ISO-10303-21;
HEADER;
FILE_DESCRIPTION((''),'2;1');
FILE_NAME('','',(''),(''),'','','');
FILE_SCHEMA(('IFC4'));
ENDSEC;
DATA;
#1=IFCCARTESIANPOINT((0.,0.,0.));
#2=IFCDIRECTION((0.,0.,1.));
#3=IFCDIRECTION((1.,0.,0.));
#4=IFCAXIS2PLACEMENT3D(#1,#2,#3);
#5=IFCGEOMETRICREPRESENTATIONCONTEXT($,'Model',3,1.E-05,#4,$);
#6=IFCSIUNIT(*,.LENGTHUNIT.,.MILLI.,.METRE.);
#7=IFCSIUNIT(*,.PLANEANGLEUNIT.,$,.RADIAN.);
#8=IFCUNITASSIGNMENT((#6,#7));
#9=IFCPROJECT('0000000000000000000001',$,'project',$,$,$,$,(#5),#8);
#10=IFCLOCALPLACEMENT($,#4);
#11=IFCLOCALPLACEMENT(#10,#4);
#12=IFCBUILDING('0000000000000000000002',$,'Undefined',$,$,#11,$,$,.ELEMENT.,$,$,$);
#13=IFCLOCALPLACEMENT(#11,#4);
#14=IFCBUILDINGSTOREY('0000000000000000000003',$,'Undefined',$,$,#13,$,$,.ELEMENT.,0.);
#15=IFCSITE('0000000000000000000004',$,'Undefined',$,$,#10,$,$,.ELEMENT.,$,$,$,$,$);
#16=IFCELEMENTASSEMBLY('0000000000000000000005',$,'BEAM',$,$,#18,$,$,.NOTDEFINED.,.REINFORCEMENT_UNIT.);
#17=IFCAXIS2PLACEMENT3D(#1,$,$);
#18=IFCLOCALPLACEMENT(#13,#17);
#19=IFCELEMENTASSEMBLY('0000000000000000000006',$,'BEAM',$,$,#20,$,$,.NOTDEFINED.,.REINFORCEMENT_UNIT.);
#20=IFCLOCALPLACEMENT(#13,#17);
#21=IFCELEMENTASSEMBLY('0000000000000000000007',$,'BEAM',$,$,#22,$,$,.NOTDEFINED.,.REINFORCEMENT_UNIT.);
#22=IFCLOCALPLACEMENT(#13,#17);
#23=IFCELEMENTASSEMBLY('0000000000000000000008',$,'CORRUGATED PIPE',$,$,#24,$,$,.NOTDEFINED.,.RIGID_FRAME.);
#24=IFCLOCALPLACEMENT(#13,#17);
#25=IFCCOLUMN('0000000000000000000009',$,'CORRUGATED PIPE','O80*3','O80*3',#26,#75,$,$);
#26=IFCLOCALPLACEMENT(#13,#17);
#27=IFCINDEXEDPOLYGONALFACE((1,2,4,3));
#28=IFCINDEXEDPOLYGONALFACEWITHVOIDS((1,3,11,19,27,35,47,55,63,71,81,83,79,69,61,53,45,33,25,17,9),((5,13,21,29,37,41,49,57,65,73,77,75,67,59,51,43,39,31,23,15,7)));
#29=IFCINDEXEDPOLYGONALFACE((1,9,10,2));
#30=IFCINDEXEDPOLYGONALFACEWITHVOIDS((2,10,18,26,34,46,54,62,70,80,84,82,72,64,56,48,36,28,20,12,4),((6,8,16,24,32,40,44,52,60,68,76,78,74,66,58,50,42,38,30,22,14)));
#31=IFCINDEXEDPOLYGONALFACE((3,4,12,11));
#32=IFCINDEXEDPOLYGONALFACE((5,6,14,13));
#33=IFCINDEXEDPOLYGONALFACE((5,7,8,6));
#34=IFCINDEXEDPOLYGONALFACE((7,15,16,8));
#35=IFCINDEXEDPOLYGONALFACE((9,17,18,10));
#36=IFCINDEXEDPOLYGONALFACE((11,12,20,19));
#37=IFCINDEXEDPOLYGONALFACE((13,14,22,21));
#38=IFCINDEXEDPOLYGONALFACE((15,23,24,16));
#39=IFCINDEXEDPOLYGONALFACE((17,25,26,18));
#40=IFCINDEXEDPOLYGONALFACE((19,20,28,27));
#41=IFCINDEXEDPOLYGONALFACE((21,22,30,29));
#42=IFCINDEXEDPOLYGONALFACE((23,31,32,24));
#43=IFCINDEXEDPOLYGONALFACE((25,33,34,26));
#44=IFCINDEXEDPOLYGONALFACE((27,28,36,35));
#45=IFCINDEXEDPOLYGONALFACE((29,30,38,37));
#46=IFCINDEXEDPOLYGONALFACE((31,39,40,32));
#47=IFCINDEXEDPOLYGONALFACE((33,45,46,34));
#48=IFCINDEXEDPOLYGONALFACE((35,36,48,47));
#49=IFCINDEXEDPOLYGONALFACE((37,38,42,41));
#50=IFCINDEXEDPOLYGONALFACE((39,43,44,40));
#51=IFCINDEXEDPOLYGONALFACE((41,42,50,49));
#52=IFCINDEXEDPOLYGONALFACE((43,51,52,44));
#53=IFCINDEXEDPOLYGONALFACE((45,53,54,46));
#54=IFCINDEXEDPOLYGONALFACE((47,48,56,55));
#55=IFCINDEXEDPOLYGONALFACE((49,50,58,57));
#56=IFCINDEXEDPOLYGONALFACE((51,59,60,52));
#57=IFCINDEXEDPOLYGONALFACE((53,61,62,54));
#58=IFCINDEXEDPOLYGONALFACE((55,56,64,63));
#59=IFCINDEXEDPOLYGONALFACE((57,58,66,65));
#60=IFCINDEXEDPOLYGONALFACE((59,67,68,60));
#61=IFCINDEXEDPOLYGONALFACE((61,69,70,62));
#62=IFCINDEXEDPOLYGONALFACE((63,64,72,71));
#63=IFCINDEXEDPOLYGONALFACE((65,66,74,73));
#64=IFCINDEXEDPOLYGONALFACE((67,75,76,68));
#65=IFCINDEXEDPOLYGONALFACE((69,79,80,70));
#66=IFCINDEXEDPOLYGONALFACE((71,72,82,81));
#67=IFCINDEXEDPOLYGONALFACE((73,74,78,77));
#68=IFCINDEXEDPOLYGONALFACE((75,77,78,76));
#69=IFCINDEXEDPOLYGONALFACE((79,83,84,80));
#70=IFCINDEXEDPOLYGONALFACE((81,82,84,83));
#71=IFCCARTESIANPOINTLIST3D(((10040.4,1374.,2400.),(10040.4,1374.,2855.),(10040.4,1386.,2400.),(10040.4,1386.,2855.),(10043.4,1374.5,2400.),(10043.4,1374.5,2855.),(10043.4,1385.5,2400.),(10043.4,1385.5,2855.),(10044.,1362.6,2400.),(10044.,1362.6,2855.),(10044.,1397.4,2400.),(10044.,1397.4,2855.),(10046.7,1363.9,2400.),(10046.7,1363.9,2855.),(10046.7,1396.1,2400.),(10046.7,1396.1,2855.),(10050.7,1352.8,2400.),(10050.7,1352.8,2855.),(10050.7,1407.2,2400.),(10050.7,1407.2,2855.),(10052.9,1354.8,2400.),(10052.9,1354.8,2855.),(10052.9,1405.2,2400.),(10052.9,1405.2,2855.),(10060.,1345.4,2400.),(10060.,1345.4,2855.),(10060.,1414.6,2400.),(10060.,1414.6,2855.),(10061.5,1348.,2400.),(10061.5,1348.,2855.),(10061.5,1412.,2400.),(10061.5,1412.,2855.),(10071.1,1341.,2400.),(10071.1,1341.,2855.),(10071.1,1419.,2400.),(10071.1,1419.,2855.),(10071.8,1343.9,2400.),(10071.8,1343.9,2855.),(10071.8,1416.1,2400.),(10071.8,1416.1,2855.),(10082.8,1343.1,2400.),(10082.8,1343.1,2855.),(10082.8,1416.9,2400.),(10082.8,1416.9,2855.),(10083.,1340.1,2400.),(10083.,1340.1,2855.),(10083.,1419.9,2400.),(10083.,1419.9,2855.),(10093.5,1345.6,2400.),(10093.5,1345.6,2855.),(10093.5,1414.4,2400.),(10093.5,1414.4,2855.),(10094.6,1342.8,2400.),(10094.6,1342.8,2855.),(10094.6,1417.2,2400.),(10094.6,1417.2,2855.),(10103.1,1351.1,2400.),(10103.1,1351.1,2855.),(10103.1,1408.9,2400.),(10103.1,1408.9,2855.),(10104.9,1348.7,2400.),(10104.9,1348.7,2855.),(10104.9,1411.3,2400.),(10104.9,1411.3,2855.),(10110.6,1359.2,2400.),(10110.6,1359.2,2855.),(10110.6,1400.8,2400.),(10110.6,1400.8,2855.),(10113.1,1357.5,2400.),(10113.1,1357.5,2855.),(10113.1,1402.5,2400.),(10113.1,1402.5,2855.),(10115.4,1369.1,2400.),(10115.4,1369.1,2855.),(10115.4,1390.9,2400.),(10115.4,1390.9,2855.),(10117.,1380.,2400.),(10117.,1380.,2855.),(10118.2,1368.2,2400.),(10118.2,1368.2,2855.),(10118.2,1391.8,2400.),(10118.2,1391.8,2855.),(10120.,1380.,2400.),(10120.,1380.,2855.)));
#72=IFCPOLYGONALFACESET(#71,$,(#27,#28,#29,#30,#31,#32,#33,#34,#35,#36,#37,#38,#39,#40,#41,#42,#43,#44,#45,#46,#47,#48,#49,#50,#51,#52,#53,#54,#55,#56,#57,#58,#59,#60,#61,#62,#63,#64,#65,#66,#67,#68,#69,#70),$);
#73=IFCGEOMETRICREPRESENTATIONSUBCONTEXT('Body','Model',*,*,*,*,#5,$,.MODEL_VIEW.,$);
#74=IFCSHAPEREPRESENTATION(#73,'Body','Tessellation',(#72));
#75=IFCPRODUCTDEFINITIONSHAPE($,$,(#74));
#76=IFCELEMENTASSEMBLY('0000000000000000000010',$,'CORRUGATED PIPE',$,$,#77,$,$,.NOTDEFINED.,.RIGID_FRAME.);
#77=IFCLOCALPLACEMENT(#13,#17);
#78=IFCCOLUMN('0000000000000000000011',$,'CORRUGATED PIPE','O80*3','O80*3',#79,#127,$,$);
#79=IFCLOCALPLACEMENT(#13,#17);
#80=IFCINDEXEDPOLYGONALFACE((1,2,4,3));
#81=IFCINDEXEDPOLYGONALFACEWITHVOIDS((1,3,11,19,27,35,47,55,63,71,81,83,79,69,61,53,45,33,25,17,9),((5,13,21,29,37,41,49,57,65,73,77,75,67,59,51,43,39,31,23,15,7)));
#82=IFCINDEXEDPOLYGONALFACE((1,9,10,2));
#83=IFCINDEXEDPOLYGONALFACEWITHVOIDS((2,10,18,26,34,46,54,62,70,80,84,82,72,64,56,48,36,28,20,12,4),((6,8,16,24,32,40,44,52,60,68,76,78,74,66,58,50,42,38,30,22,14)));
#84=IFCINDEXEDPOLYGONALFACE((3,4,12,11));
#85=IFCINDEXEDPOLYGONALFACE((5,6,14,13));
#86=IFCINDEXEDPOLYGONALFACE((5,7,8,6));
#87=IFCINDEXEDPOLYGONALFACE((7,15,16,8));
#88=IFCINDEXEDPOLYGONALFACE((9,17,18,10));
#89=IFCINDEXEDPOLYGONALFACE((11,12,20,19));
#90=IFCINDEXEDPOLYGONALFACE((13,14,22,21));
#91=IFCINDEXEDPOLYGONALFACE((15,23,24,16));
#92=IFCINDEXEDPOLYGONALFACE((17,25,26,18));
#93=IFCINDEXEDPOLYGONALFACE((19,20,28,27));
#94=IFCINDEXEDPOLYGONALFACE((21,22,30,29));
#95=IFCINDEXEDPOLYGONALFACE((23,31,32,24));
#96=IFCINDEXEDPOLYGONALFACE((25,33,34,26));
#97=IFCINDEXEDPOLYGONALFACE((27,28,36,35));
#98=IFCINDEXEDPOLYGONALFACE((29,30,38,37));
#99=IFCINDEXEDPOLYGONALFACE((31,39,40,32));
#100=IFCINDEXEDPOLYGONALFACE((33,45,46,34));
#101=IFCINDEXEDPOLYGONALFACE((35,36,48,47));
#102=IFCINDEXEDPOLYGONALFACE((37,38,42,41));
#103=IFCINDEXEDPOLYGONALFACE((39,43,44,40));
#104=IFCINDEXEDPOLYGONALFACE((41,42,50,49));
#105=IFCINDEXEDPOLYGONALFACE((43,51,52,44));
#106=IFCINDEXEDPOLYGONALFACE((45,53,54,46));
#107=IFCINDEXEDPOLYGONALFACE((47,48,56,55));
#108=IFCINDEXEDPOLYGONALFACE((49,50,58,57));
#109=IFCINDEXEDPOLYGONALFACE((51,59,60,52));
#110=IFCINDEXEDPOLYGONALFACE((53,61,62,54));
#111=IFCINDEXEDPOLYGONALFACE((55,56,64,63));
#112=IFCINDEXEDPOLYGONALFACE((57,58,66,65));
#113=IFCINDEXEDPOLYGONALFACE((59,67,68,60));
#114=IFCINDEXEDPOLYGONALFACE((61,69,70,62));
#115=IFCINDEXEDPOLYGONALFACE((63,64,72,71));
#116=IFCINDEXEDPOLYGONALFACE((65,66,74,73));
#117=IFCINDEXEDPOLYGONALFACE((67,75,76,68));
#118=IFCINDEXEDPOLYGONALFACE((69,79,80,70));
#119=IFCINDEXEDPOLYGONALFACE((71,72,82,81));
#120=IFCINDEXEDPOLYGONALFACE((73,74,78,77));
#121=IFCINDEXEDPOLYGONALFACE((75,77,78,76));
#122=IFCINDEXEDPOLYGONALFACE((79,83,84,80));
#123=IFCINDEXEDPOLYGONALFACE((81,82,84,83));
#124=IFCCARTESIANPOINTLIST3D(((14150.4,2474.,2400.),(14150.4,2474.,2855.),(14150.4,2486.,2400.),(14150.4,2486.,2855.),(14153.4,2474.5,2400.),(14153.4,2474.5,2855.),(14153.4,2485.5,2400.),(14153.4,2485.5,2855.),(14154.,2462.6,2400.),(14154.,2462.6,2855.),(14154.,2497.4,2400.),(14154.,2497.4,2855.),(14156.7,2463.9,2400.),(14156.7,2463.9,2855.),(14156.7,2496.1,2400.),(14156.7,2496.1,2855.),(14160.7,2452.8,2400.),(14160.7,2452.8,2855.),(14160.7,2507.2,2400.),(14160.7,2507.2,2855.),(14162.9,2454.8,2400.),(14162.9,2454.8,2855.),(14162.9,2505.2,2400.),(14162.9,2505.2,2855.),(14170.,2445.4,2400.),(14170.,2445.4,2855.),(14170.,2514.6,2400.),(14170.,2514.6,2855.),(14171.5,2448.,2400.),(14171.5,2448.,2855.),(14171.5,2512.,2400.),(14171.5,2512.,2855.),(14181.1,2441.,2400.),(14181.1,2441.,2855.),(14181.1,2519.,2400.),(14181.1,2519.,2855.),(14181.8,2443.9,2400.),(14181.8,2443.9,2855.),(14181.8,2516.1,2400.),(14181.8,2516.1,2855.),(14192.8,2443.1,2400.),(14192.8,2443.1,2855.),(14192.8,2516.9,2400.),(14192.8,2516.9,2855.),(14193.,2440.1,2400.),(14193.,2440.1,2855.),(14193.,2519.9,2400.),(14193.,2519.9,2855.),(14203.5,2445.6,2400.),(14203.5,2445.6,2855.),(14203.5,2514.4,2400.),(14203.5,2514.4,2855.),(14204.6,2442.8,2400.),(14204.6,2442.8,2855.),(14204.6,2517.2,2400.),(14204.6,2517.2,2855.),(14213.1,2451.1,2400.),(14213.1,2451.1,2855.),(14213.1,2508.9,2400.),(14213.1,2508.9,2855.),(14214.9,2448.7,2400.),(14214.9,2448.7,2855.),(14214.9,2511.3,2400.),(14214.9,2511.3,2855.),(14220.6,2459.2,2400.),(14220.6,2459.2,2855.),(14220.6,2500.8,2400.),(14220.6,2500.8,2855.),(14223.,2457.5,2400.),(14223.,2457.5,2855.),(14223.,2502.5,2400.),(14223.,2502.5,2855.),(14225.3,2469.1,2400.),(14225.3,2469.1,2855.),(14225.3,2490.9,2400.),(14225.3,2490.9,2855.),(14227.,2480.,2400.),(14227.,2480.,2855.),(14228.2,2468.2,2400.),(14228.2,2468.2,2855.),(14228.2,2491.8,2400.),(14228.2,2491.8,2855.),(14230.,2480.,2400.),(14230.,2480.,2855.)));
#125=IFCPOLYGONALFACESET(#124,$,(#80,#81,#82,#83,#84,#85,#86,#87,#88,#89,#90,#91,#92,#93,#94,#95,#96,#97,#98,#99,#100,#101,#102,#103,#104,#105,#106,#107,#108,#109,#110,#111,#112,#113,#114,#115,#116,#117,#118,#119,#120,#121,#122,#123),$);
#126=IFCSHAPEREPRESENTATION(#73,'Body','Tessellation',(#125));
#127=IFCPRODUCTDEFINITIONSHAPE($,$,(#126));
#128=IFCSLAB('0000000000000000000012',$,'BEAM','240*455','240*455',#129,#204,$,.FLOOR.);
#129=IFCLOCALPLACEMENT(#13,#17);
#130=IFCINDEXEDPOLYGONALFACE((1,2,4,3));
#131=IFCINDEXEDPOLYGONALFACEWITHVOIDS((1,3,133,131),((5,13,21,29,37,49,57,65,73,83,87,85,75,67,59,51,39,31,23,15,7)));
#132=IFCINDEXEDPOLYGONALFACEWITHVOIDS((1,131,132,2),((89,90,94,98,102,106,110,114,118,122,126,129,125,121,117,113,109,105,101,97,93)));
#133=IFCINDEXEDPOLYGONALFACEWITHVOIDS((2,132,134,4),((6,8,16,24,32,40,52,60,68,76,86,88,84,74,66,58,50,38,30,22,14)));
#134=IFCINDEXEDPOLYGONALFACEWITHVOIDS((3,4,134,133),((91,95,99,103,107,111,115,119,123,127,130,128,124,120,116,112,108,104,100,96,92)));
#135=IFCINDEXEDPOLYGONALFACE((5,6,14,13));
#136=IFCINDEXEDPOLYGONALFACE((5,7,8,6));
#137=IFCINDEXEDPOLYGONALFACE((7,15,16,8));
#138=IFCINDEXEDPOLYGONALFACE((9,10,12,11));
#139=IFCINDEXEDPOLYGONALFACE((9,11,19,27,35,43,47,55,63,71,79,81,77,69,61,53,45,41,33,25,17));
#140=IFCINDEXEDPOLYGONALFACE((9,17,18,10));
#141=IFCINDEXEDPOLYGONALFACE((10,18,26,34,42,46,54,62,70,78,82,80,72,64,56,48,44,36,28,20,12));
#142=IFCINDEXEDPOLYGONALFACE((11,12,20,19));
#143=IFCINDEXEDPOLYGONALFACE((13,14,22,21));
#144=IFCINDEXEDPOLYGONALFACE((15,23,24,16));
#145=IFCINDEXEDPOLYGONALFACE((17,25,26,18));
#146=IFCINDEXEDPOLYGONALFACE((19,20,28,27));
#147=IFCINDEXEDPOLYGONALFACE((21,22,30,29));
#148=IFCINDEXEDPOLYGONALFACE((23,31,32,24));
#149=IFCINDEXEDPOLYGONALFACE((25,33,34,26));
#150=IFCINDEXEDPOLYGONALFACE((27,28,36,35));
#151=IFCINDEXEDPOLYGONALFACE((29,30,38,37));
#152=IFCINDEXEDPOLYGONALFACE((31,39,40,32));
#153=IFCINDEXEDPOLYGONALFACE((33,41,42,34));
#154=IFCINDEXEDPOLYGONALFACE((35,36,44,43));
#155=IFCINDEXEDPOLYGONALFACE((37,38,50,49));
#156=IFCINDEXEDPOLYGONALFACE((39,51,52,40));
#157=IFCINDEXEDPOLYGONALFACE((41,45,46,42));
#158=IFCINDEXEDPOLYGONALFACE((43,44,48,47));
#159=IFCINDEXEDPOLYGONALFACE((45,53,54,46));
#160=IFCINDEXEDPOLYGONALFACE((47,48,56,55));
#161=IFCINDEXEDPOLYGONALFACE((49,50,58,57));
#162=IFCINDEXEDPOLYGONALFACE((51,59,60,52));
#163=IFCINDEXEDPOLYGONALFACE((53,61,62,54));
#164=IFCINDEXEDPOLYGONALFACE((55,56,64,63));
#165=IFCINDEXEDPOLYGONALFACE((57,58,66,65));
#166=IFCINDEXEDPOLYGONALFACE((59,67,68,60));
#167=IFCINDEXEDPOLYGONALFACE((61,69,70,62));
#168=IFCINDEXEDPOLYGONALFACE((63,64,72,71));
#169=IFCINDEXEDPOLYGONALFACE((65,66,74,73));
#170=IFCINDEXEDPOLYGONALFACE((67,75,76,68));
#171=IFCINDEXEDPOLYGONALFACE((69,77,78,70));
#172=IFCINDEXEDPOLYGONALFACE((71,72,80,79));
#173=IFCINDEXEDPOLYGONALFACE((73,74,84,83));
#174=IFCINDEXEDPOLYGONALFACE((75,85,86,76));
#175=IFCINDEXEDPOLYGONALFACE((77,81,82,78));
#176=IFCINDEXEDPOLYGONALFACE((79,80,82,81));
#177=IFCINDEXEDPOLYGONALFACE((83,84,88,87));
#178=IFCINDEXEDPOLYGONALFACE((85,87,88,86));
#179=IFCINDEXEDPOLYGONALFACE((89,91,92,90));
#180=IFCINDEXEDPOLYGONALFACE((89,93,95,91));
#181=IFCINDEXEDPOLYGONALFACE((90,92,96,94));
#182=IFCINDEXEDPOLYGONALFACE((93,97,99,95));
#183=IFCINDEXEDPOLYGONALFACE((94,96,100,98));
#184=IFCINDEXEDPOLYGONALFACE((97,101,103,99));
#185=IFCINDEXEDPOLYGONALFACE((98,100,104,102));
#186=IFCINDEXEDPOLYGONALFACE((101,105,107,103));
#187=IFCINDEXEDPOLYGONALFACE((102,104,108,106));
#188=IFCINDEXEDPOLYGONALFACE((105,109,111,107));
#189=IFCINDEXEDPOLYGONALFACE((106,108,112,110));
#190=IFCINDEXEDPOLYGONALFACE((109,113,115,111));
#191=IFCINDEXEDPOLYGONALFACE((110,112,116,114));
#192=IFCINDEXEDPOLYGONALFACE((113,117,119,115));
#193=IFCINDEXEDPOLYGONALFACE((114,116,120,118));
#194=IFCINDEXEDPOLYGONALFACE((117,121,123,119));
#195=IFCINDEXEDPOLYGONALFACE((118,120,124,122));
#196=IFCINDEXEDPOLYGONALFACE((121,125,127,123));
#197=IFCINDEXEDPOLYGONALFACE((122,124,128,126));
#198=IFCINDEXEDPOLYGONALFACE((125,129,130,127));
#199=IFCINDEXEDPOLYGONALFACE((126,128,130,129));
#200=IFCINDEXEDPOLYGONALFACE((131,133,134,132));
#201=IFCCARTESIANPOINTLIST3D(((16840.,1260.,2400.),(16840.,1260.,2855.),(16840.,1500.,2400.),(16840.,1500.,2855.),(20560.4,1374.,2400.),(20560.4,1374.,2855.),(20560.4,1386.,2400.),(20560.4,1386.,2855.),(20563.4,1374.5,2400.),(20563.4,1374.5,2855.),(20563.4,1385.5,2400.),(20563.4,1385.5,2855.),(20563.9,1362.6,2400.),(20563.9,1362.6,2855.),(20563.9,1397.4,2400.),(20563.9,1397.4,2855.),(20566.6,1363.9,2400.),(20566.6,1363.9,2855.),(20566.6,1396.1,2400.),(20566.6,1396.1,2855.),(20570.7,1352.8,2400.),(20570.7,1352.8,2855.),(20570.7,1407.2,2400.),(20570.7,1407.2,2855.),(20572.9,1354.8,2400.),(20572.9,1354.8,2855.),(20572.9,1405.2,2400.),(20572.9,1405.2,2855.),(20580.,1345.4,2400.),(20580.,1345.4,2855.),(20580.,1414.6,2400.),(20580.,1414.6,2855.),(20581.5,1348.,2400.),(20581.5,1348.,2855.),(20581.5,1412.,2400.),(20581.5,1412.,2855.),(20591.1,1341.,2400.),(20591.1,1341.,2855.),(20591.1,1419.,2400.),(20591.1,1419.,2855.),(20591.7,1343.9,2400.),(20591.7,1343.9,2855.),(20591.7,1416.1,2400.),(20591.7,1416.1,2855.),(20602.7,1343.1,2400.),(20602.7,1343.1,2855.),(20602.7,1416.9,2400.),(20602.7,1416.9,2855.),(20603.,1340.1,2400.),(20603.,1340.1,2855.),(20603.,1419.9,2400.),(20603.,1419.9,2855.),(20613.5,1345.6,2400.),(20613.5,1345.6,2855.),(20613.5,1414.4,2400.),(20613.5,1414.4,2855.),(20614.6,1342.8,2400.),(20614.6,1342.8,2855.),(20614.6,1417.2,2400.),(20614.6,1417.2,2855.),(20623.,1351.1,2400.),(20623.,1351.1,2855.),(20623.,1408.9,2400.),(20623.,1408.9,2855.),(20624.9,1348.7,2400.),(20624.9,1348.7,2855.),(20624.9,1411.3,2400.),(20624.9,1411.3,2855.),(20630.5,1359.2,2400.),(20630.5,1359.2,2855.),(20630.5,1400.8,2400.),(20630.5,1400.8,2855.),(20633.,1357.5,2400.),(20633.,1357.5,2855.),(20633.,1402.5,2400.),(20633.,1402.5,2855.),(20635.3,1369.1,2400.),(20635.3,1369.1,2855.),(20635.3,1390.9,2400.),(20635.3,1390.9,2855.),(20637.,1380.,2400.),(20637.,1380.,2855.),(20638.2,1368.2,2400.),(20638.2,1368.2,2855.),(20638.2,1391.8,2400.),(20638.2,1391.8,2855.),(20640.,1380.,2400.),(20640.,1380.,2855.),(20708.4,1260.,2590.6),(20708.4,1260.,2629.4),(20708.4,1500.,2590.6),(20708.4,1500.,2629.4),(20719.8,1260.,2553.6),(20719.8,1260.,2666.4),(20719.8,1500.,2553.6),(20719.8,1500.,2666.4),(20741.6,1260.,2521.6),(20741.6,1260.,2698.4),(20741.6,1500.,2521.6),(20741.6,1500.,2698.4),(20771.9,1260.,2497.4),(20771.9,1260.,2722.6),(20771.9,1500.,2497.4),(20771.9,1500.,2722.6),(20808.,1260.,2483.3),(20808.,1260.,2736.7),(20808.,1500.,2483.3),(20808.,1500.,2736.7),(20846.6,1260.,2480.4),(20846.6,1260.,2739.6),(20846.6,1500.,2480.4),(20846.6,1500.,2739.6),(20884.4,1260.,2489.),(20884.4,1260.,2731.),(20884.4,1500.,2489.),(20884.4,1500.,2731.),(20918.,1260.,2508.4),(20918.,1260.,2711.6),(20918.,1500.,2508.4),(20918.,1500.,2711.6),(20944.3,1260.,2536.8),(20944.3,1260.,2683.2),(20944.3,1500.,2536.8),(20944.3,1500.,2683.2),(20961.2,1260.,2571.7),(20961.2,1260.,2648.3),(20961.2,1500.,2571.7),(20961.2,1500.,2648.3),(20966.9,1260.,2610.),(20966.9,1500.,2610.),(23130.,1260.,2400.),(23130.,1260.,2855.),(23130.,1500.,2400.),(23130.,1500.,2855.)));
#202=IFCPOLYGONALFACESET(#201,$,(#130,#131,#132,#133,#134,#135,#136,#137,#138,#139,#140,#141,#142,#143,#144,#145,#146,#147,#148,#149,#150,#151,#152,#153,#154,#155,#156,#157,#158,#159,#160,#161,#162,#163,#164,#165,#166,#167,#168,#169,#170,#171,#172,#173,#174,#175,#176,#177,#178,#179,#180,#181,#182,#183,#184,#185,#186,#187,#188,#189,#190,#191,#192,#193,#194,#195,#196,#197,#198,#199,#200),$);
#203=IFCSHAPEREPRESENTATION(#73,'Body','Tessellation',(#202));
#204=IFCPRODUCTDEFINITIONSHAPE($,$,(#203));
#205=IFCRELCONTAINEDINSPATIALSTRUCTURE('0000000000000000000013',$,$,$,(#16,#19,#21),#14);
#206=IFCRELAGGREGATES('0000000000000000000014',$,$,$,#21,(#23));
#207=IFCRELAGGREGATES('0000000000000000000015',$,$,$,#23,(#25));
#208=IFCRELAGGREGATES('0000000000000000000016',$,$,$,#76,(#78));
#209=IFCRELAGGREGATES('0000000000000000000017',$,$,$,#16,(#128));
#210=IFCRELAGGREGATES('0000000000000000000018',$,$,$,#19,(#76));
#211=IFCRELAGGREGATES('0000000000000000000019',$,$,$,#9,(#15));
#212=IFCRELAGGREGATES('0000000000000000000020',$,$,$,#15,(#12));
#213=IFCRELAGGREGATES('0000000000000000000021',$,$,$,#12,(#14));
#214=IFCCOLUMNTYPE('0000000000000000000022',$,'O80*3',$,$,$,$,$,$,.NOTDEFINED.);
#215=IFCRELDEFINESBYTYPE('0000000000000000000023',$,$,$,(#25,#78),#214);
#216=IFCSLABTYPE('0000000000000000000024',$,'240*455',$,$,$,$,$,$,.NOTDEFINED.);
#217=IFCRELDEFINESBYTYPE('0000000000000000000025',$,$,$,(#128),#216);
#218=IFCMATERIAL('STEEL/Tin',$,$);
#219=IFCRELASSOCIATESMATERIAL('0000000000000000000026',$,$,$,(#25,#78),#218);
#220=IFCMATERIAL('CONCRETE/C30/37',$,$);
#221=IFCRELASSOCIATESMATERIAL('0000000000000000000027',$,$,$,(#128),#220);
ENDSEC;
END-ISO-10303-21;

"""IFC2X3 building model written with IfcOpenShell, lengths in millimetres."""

from ifc_helpers import new_model, si_unit, frame, origin_with_axes, origin_2d_with_axis, place, context, subcontext, project, spatial, polyline, circle, hollow_circle, outline, extrude, boolean, material, type_object, element, aggregate, save


model = new_model("IFC2X3")

# Units and contexts
model_context = context("Model", 3, precision=1e-05, world=origin_with_axes())
body_context = subcontext(model_context, "Body", "Model", "MODEL_VIEW")
ifc_project = project(units=[si_unit("LENGTHUNIT", "METRE", prefix="MILLI"), si_unit("PLANEANGLEUNIT", "RADIAN")], contexts=[model_context])

# Site, building, storey
site_placement = place(None, origin_with_axes())
site = spatial("IfcSite", under=ifc_project, at=site_placement, Name="Undefined", CompositionType="ELEMENT")
building_placement = place(site_placement, origin_with_axes())
building = spatial("IfcBuilding", under=site, at=building_placement, Name="Undefined", CompositionType="ELEMENT")
storey_placement = place(building_placement, origin_with_axes())
storey = spatial("IfcBuildingStorey", under=building, at=storey_placement, Name="Undefined", CompositionType="ELEMENT", Elevation=0.0)

# Element assembly
assembly_1_placement = place(storey_placement, origin_with_axes())
assembly_1 = element("IfcElementAssembly", 1, at=assembly_1_placement, inside=storey, Name="BEAM", AssemblyPlace="NOTDEFINED", PredefinedType="REINFORCEMENT_UNIT")
ifc_material_1 = material(Name="STEEL/Tin")
column_type = type_object("IfcColumnType", Name="O80*3", PredefinedType="NOTDEFINED")

# Element assembly
assembly_2_placement = place(storey_placement, origin_with_axes())
assembly_2 = element("IfcElementAssembly", 2, at=assembly_2_placement, inside=storey, Name="BEAM", AssemblyPlace="NOTDEFINED", PredefinedType="REINFORCEMENT_UNIT")

# Element assemblies, column
assembly_3_placement = place(storey_placement, origin_with_axes())
assembly_3 = element("IfcElementAssembly", 3, at=assembly_3_placement, inside=storey, Name="BEAM", AssemblyPlace="NOTDEFINED", PredefinedType="REINFORCEMENT_UNIT")
assembly_4_placement = place(assembly_3_placement, origin_with_axes())
assembly_4 = element("IfcElementAssembly", 4, at=assembly_4_placement, Name="CORRUGATED PIPE", AssemblyPlace="NOTDEFINED", PredefinedType="RIGID_FRAME")
aggregate(assembly_3, [assembly_4])
column_1_placement = place(assembly_4_placement, frame((10080.0, 1380.0, 2400.0), z_axis=(0.0, 0.0, 1.0), x_axis=(0.0, -1.0, 0.0)))
column_1 = element("IfcColumn", 5, at=column_1_placement, type_object=column_type, material=ifc_material_1, Name="CORRUGATED PIPE", Description="O80*3", ObjectType="O80*3", context=body_context, shape_type="SweptSolid", body=[
    extrude(hollow_circle(Radius=40.0, WallThickness=3.0, at=origin_2d_with_axis()), frame((0.0, 0.0, 455.0), z_axis=(0.0, 0.0, -1.0), x_axis=(0.0, 1.0, 0.0)), (0.0, 0.0, 1.0), 455.0),
])
aggregate(assembly_4, [column_1])

# Element assembly, column
assembly_5_placement = place(assembly_2_placement, origin_with_axes())
assembly_5 = element("IfcElementAssembly", 6, at=assembly_5_placement, Name="CORRUGATED PIPE", AssemblyPlace="NOTDEFINED", PredefinedType="RIGID_FRAME")
column_2_placement = place(assembly_5_placement, frame((14190.0, 2480.0, 2400.0), z_axis=(0.0, 0.0, 1.0), x_axis=(0.0, -1.0, 0.0)))
column_2 = element("IfcColumn", 7, at=column_2_placement, type_object=column_type, material=ifc_material_1, Name="CORRUGATED PIPE", Description="O80*3", ObjectType="O80*3", context=body_context, shape_type="SweptSolid", body=[
    extrude(hollow_circle(Radius=40.0, WallThickness=3.0, at=origin_2d_with_axis()), frame((0.0, 0.0, 455.0), z_axis=(0.0, 0.0, -1.0), x_axis=(0.0, 1.0, 0.0)), (0.0, 0.0, 1.0), 455.0),
])
aggregate(assembly_5, [column_2])

# Slab
ifc_material_2 = material(Name="CONCRETE/C30/37")
slab_type_1 = type_object("IfcSlabType", Name="240*455", PredefinedType="NOTDEFINED")
slab_1_placement = place(assembly_1_placement, frame((16840.0, 1380.0, 2400.0), z_axis=(0.0, 1.0, 0.0), x_axis=(0.0, 0.0, 1.0)))
slab_1 = element("IfcSlab", 8, at=slab_1_placement, type_object=slab_type_1, material=ifc_material_2, Name="BEAM", Description="240*455", ObjectType="240*455", PredefinedType="FLOOR", context=body_context, shape_type="CSG", body=[
    boolean("DIFFERENCE", boolean("DIFFERENCE", extrude(outline(polyline([(0.0, 0.0), (455.0, 0.0), (455.0, 6290.0), (0.0, 6290.0), (0.0, 0.0)])), frame((0.0, 0.0, -120.0), z_axis=(0.0, 0.0, 1.0), x_axis=(1.0, 0.0, 0.0)), (0.0, 0.0, 1.0), 240.0), extrude(hollow_circle(Radius=40.0, WallThickness=3.0, at=origin_2d_with_axis()), frame((455.0, 3760.0, 0.0), z_axis=(-1.0, 0.0, 0.0), x_axis=(0.0, 1.0, 0.0)), (0.0, 0.0, 1.0), 455.0)), extrude(circle(Radius=130.0, at=origin_2d_with_axis()), frame((210.0, 3996.9, 125.0), z_axis=(0.0, 0.0, -1.0), x_axis=(0.0, 1.0, 0.0)), (0.0, 0.0, 1.0), 250.0)),
])

aggregate(assembly_1, [slab_1])
aggregate(assembly_2, [assembly_5])

save(model, "model.ifc")
